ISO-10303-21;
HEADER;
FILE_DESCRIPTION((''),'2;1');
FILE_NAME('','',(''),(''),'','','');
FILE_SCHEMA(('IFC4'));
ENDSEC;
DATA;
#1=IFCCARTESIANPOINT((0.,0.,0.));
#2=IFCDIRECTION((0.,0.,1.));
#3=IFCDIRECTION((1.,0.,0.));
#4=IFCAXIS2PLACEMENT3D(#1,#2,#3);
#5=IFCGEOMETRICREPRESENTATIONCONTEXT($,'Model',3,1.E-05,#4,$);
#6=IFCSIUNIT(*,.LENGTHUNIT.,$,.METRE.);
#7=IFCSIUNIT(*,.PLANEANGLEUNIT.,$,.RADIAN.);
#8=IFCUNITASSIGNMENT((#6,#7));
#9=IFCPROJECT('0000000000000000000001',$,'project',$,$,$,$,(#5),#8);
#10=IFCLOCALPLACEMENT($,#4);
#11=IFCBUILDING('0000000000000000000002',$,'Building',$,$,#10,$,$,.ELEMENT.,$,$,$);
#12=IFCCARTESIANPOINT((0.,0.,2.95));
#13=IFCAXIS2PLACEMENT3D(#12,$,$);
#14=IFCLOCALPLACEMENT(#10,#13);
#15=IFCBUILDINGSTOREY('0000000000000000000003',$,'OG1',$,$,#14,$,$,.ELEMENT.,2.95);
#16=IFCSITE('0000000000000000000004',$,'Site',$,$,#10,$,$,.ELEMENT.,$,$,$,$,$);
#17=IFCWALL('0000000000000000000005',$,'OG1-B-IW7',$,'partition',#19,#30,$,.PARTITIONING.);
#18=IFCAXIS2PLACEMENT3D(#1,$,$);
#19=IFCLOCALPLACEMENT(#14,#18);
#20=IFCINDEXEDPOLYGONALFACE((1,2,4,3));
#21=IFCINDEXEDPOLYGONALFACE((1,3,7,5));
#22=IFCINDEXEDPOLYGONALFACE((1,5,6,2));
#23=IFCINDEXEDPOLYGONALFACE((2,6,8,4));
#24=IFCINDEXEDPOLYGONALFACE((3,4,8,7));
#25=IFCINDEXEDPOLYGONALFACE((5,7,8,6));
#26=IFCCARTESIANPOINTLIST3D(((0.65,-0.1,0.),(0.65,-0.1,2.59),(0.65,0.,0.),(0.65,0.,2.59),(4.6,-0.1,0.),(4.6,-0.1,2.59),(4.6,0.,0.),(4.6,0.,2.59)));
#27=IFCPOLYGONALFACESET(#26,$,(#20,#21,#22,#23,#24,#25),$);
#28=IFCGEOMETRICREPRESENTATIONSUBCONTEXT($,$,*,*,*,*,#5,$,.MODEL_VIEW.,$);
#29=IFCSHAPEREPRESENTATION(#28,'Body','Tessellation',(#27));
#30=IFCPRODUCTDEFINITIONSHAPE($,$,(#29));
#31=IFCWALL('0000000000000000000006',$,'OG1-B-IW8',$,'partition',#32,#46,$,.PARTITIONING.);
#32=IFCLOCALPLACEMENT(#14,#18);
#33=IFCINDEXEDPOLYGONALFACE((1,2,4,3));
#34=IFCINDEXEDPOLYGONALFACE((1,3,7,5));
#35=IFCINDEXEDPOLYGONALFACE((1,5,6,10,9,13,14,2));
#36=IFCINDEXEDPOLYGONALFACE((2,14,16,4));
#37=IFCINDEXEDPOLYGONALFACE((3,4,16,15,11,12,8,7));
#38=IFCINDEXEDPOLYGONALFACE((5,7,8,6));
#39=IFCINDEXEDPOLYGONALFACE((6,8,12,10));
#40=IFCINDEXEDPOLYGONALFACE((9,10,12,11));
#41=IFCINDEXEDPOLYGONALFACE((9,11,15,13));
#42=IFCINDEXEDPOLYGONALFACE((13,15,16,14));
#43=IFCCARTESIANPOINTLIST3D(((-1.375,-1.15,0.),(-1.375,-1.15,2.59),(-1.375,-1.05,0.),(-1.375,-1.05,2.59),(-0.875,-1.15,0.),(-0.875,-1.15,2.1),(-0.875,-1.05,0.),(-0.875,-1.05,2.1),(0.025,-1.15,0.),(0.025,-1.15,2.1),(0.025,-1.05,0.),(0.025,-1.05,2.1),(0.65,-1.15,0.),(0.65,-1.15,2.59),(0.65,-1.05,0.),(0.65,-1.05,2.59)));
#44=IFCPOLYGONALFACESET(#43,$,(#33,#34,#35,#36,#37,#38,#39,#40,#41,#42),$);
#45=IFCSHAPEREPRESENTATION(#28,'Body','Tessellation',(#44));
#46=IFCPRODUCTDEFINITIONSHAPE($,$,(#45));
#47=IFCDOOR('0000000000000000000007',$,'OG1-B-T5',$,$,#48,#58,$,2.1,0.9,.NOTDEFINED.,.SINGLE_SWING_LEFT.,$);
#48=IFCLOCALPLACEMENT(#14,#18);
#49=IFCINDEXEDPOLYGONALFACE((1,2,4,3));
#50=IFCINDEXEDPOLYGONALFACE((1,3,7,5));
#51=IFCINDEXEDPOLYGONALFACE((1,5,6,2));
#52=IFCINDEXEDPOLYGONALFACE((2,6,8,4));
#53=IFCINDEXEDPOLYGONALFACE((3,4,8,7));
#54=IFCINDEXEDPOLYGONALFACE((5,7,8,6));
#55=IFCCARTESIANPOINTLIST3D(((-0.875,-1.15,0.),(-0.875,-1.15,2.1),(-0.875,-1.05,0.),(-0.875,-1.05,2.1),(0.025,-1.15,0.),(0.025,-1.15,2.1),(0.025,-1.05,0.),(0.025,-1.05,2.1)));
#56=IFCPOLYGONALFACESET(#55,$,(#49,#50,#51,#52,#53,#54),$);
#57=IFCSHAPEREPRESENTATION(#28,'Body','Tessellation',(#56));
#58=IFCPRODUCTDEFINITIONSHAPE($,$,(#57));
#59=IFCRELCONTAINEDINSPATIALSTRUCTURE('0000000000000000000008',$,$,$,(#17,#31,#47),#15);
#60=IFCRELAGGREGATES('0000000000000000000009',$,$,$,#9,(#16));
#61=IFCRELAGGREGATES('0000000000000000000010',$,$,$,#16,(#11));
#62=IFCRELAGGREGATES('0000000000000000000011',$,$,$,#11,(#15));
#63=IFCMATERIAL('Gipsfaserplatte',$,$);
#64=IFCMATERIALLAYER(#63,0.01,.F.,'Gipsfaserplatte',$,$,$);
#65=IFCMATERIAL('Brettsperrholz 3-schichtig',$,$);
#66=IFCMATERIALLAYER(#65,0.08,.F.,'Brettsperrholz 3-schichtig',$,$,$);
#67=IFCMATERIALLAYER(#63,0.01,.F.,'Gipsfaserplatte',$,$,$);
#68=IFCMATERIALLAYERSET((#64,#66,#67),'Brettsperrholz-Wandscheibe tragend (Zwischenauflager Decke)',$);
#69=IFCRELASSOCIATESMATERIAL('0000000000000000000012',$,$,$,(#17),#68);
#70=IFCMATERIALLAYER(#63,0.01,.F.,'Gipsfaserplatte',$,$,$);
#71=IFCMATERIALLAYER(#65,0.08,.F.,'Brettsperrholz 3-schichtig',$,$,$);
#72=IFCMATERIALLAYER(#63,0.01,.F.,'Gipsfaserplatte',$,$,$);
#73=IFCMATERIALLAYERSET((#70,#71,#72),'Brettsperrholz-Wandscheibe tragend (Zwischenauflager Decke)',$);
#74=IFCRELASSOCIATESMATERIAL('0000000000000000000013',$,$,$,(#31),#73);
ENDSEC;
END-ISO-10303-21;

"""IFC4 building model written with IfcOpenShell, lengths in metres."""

from ifc_helpers import new_model, si_unit, frame, frame_2d, origin, origin_with_axes, place, context, subcontext, project, spatial, rectangle, extrude, material, layer, layer_set, element, fill, save


model = new_model("IFC4")

# Units and contexts
model_context = context("Model", 3, precision=1e-05, world=origin_with_axes())
sub_context = subcontext(model_context, None, None, "MODEL_VIEW")
ifc_project = project(units=[si_unit("LENGTHUNIT", "METRE"), si_unit("PLANEANGLEUNIT", "RADIAN")], contexts=[model_context])

# Site, building, storey
placement = place(None, origin_with_axes())
site = spatial("IfcSite", under=ifc_project, at=placement, Name="Site", CompositionType="ELEMENT")
building = spatial("IfcBuilding", under=site, at=placement, Name="Building", CompositionType="ELEMENT")
storey_placement = place(placement, frame((0.0, 0.0, 2.95)))
storey = spatial("IfcBuildingStorey", under=building, at=storey_placement, Name="OG1", CompositionType="ELEMENT", Elevation=2.95)

# Shared definitions
ifc_material_1 = material(Name="Gipsfaserplatte")

# Wall
ifc_material_2 = material(Name="Brettsperrholz 3-schichtig")
ifc_layer_1 = layer(ifc_material_1, 0.01, ventilated=False, Name="Gipsfaserplatte")
ifc_layer_2 = layer(ifc_material_2, 0.08, ventilated=False, Name="Brettsperrholz 3-schichtig")
ifc_layer_3 = layer(ifc_material_1, 0.01, ventilated=False, Name="Gipsfaserplatte")
ifc_layer_set_1 = layer_set([ifc_layer_1, ifc_layer_2, ifc_layer_3], Name="Brettsperrholz-Wandscheibe tragend (Zwischenauflager Decke)")
wall_1_placement = place(storey_placement, frame((0.65, -0.05, 0.0), z_axis=(0.0, 0.0, 1.0), x_axis=(1.0, 0.0, 0.0)))
element("IfcWall", 1, at=wall_1_placement, inside=storey, material=ifc_layer_set_1, Name="OG1-B-IW7", ObjectType="partition", PredefinedType="PARTITIONING", context=sub_context, shape_type="SweptSolid", body=[
    extrude(rectangle(XDim=3.95, YDim=0.1, at=frame_2d((1.975, 0.0))), origin(), (0.0, 0.0, 1.0), 2.59),
])

# Wall, opening, door
ifc_layer_4 = layer(ifc_material_1, 0.01, ventilated=False, Name="Gipsfaserplatte")
ifc_layer_5 = layer(ifc_material_2, 0.08, ventilated=False, Name="Brettsperrholz 3-schichtig")
ifc_layer_6 = layer(ifc_material_1, 0.01, ventilated=False, Name="Gipsfaserplatte")
ifc_layer_set_2 = layer_set([ifc_layer_4, ifc_layer_5, ifc_layer_6], Name="Brettsperrholz-Wandscheibe tragend (Zwischenauflager Decke)")
wall_2_placement = place(storey_placement, frame((-1.375, -1.1, 0.0), z_axis=(0.0, 0.0, 1.0), x_axis=(1.0, 0.0, 0.0)))
wall_2 = element("IfcWall", 2, at=wall_2_placement, inside=storey, material=ifc_layer_set_2, Name="OG1-B-IW8", ObjectType="partition", PredefinedType="PARTITIONING", context=sub_context, shape_type="SweptSolid", body=[
    extrude(rectangle(XDim=2.025, YDim=0.1, at=frame_2d((1.0125, 0.0))), origin(), (0.0, 0.0, 1.0), 2.59),
])
opening_1_placement = place(wall_2_placement, frame((0.95, 0.1, 0.0), z_axis=(0.0, -1.0, 0.0), x_axis=(1.0, 0.0, 0.0)))
opening_1 = element("IfcOpeningElement", 3, at=opening_1_placement, cuts=wall_2, PredefinedType="OPENING", context=sub_context, shape_type="SweptSolid", body=[
    extrude(rectangle(XDim=0.9, YDim=2.1, at=frame_2d((0.0, 1.05))), origin(), (0.0, 0.0, 1.0), 0.2),
])
door_1_placement = place(wall_2_placement, frame((0.95, 0.05, 0.0), z_axis=(0.0, -1.0, 0.0), x_axis=(1.0, 0.0, 0.0)))
door_1 = element("IfcDoor", 4, at=door_1_placement, inside=storey, Name="OG1-B-T5", OperationType="SINGLE_SWING_LEFT", OverallHeight=2.1, OverallWidth=0.9, PredefinedType="NOTDEFINED", context=sub_context, shape_type="SweptSolid", body=[
    extrude(rectangle(XDim=0.9, YDim=2.1, at=frame_2d((0.0, 1.05))), origin(), (0.0, 0.0, 1.0), 0.1),
])
fill(opening_1, door_1)

save(model, "model.ifc")
